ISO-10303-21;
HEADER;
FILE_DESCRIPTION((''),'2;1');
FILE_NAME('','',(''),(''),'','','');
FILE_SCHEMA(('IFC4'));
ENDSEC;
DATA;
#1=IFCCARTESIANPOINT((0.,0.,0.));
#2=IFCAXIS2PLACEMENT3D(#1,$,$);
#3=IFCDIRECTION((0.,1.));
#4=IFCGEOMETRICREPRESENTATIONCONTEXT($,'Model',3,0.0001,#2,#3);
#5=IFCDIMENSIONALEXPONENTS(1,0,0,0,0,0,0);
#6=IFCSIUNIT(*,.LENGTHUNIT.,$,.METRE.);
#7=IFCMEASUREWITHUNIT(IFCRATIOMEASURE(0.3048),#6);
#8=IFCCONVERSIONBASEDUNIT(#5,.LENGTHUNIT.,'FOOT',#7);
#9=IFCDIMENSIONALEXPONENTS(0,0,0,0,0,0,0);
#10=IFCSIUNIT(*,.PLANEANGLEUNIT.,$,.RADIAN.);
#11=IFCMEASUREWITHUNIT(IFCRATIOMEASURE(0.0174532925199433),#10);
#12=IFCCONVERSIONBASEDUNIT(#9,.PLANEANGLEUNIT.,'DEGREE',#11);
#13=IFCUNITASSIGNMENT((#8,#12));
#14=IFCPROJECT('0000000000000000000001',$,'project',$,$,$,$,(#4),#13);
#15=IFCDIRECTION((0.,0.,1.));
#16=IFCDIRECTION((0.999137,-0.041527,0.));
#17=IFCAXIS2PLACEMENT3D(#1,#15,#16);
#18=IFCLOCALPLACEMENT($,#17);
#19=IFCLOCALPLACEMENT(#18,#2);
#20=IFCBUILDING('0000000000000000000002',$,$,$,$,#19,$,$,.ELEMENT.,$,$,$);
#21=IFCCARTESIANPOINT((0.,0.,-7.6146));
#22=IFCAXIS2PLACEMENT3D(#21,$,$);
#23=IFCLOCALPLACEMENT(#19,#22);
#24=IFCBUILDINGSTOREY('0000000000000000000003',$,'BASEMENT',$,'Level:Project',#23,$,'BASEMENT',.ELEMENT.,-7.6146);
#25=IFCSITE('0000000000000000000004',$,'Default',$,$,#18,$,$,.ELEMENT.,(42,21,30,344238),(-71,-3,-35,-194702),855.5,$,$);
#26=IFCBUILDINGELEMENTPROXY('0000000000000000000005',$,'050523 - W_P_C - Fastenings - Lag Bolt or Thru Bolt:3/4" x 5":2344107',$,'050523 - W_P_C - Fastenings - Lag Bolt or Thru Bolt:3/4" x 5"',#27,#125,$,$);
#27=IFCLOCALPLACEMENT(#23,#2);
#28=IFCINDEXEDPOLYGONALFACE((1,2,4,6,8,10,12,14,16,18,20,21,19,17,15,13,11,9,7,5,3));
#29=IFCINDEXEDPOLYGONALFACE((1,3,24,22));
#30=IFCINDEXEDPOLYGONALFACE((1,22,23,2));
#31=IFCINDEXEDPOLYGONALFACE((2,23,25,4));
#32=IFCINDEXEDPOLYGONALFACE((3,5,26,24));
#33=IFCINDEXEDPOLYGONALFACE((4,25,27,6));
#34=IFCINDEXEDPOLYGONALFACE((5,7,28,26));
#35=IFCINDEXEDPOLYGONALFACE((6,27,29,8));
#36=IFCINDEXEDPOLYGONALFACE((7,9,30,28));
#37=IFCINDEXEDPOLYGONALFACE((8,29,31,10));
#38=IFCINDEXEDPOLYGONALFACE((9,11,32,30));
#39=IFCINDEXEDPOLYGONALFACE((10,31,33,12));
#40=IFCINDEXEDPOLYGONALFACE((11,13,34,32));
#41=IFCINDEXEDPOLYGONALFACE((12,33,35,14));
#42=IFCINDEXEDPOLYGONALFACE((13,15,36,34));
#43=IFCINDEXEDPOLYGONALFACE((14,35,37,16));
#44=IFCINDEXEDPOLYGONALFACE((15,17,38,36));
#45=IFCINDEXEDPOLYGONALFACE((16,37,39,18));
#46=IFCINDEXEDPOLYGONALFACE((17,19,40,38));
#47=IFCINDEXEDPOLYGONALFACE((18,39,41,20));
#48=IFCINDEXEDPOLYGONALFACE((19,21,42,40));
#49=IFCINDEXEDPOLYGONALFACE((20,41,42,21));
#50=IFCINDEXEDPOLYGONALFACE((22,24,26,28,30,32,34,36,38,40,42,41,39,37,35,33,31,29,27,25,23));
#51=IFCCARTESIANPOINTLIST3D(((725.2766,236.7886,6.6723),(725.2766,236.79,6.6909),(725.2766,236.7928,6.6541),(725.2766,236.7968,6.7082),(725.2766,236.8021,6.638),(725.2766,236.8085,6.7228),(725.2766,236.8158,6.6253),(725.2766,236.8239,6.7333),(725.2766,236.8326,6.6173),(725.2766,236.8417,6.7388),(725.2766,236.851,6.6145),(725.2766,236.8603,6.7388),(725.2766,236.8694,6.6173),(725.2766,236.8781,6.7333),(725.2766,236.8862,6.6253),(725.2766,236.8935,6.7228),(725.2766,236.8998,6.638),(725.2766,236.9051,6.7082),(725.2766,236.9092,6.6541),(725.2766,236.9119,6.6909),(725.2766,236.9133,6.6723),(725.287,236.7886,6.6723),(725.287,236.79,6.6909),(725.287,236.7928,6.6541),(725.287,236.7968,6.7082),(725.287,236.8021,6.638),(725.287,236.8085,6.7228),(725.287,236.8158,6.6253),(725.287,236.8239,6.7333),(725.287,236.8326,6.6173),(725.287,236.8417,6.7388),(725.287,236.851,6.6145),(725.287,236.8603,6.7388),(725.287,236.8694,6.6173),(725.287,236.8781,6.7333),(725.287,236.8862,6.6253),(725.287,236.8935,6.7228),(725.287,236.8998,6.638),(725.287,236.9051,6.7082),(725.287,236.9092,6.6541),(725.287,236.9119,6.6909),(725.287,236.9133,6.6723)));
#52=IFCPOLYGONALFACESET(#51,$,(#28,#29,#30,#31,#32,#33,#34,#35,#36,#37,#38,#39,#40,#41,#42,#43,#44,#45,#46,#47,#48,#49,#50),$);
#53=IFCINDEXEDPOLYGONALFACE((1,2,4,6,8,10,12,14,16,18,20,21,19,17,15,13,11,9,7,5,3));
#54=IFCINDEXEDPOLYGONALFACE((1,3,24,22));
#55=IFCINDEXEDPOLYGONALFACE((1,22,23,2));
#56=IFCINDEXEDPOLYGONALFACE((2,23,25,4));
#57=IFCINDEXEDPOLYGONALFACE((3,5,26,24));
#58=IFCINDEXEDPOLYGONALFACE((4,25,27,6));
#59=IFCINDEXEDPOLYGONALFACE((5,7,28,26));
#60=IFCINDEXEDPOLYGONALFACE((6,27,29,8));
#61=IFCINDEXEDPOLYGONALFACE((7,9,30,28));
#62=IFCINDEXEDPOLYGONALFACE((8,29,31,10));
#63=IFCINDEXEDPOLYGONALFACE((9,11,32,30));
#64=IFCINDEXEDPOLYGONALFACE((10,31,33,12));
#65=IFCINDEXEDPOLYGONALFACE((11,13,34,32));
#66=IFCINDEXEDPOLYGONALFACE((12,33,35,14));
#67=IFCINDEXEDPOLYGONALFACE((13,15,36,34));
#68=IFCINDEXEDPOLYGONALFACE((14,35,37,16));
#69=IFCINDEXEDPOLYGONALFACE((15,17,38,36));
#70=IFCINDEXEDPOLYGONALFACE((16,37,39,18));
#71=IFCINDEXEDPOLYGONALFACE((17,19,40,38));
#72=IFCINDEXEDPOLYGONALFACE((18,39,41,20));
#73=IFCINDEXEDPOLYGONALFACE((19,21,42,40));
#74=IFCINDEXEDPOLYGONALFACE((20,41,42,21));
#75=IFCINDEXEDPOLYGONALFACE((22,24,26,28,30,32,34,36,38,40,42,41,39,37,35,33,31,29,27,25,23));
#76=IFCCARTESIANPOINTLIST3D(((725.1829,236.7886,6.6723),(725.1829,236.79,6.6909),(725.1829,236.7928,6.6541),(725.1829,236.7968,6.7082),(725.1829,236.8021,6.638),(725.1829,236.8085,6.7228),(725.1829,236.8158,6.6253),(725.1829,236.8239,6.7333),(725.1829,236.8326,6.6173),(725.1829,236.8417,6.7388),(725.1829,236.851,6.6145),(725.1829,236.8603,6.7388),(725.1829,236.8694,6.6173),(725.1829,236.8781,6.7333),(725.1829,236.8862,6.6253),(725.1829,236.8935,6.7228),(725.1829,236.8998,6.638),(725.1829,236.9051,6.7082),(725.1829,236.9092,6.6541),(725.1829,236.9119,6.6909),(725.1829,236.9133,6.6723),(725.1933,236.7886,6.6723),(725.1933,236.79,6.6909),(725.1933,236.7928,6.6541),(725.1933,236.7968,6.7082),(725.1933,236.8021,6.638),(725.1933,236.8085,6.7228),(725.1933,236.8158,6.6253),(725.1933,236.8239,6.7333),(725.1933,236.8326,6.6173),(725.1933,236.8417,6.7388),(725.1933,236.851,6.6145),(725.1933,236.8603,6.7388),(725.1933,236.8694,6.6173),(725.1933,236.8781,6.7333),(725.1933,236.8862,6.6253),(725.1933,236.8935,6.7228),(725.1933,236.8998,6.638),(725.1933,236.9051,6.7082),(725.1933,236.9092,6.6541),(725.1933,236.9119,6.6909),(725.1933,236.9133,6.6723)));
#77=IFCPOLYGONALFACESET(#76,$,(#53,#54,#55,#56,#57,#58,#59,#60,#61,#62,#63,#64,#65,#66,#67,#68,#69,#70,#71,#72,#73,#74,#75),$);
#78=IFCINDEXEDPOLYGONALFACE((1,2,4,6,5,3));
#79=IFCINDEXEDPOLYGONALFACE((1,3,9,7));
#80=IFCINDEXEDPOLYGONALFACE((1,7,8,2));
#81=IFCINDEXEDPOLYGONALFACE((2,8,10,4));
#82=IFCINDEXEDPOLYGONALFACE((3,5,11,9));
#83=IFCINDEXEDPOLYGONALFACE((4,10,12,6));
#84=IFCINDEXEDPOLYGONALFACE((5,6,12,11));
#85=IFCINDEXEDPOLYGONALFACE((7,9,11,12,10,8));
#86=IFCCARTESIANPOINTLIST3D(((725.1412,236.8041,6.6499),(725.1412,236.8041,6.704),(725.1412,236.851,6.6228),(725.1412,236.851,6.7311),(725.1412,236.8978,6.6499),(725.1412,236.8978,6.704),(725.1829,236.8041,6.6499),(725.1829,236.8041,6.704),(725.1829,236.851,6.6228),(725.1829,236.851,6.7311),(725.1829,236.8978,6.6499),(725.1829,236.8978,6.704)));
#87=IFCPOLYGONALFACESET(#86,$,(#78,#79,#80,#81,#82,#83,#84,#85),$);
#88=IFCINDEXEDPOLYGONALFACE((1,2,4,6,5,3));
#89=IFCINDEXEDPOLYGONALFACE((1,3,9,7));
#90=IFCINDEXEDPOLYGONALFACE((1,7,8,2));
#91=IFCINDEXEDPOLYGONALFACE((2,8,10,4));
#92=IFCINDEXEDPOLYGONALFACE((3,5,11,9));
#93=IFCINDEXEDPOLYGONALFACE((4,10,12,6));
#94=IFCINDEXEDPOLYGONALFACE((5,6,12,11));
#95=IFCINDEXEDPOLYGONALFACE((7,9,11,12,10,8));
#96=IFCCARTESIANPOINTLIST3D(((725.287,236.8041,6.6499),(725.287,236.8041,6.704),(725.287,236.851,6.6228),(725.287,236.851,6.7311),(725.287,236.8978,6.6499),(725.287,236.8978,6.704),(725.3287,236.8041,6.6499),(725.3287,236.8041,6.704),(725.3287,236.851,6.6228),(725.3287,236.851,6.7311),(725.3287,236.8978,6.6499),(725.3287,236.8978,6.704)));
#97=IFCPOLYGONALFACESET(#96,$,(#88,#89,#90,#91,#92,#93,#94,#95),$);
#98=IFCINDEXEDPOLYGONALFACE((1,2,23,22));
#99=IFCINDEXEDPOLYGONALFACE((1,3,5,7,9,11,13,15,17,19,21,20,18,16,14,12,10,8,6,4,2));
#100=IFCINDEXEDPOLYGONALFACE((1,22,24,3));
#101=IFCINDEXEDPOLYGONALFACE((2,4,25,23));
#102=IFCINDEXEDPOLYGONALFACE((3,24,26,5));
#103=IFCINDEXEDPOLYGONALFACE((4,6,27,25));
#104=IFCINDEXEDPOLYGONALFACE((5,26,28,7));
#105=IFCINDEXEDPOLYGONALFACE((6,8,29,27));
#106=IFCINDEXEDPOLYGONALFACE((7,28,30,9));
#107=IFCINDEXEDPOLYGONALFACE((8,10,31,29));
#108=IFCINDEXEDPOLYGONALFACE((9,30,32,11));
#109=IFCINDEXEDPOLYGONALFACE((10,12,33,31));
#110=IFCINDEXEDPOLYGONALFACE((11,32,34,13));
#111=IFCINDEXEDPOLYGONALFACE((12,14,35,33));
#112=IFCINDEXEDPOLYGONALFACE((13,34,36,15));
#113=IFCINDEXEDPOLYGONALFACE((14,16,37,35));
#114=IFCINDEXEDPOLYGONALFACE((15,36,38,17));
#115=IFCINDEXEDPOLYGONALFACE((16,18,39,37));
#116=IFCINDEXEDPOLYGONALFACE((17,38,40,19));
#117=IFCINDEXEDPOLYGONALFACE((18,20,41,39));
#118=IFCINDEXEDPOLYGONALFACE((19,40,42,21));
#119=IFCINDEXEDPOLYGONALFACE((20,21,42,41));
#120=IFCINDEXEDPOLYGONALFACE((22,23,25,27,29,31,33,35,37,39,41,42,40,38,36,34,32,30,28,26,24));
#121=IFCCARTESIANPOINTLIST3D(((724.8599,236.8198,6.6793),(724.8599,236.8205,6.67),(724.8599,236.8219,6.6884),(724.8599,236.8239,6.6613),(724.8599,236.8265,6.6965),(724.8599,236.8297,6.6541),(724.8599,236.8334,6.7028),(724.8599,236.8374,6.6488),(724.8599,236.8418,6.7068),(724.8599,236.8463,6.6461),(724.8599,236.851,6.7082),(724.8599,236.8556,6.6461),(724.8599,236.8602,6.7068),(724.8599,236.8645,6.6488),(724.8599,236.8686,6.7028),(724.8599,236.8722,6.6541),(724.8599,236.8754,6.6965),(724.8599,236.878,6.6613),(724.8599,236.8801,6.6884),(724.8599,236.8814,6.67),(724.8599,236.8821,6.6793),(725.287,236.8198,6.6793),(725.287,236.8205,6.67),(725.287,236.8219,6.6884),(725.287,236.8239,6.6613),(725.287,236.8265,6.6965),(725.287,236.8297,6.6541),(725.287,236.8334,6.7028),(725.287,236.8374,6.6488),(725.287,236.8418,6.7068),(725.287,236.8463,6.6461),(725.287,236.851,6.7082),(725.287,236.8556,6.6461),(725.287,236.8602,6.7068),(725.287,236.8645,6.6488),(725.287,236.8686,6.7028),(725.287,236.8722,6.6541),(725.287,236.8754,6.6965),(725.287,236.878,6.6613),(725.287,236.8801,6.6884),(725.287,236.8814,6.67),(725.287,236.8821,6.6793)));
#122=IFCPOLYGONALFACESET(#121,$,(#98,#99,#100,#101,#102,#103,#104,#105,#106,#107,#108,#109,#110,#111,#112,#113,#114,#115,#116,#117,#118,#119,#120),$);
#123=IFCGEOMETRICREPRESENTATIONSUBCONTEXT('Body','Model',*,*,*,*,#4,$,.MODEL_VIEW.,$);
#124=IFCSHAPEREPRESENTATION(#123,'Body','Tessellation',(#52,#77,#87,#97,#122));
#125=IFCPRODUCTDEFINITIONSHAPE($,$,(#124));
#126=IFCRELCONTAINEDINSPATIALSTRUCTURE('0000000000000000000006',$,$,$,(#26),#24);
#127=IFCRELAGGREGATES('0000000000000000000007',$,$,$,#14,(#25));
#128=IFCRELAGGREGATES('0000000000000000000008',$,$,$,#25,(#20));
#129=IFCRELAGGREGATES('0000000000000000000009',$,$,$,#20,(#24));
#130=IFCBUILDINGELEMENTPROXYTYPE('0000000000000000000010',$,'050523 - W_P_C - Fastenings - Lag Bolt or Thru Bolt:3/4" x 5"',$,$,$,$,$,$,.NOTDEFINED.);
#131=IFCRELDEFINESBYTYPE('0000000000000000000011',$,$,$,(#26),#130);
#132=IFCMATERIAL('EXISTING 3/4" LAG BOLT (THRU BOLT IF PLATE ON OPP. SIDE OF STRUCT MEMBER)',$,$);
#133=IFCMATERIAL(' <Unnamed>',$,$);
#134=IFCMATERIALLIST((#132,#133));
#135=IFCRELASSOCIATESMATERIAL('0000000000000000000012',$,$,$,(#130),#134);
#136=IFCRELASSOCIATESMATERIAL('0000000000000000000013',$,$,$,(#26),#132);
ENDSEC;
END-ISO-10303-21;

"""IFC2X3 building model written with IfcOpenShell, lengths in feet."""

from ifc_helpers import new_model, entity, si_unit, converted_unit, direction, frame, frame_2d, origin, place, context, subcontext, project, spatial, polyline, circle, outline, extrude, source, transform, mapped, material, material_list, type_object, type_shapes, element, save


model = new_model("IFC2X3")

# Units and contexts
model_context = context("Model", 3, precision=0.0001, world=origin(), true_north=direction((0.0, 1.0)))
body_context = subcontext(model_context, "Body", "Model", "MODEL_VIEW")
ifc_project = project(units=[converted_unit("LENGTHUNIT", "FOOT", entity("IfcRatioMeasure", 0.3048), si_unit("LENGTHUNIT", "METRE"), dimensions=[1, 0, 0, 0, 0, 0, 0]), converted_unit("PLANEANGLEUNIT", "DEGREE", entity("IfcRatioMeasure", 0.0174532925199433), si_unit("PLANEANGLEUNIT", "RADIAN"), dimensions=[0, 0, 0, 0, 0, 0, 0])], contexts=[model_context])

# Site, building, storey
site_placement = place(None, frame((0.0, 0.0, 0.0), z_axis=(0.0, 0.0, 1.0), x_axis=(0.999137, -0.041527, 0.0)))
site = spatial("IfcSite", under=ifc_project, at=site_placement, Name="Default", CompositionType="ELEMENT", RefLatitude=(42, 21, 30, 344238), RefLongitude=(-71, -3, -35, -194702), RefElevation=855.5)
building_placement = place(site_placement, origin())
building = spatial("IfcBuilding", under=site, at=building_placement, CompositionType="ELEMENT")
storey_placement = place(building_placement, frame((0.0, 0.0, -7.6146)))
storey = spatial("IfcBuildingStorey", under=building, at=storey_placement, Name="BASEMENT", ObjectType="Level:Project", LongName="BASEMENT", CompositionType="ELEMENT", Elevation=-7.6146)

# Building element proxy
ifc_material_1 = material(Name=" <Unnamed>")
ifc_material_2 = material(Name="EXISTING 3/4\" LAG BOLT (THRU BOLT IF PLATE ON OPP. SIDE OF STRUCT MEMBER)")
ifc_material_list_1 = material_list([ifc_material_2, ifc_material_1])
building_element_proxy_type_1 = type_object("IfcBuildingElementProxyType", Name="050523 - W_P_C - Fastenings - Lag Bolt or Thru Bolt:3/4\" x 5\"", PredefinedType="NOTDEFINED", material=ifc_material_list_1)
shared_shape_1 = source(origin(), body_context, "Body", "SweptSolid", [
    extrude(circle(Radius=0.0625, at=frame_2d((0.0, 0.0), x_axis=(1.0, 0.0))), frame((0.0, 0.0, 0.0), z_axis=(0.0, 0.0, 1.0), x_axis=(0.0, 1.0, 0.0)), (0.0, 0.0, 1.0), 0.0104),
    extrude(circle(Radius=0.0625, at=frame_2d((0.0, 0.0), x_axis=(1.0, 0.0))), frame((0.0, 0.0, -0.0938), z_axis=(0.0, 0.0, 1.0), x_axis=(0.0, 1.0, 0.0)), (0.0, 0.0, 1.0), 0.0104),
    extrude(outline(polyline([(-0.0271, -0.0469), (0.0271, -0.0469), (0.0541, 0.0), (0.0271, 0.0469), (-0.0271, 0.0469), (-0.0541, 0.0), (-0.0271, -0.0469)])), frame((0.0, 0.0, -0.1354), z_axis=(0.0, 0.0, 1.0), x_axis=(0.0, -1.0, 0.0)), (0.0, 0.0, 1.0), 0.0417),
    extrude(outline(polyline([(-0.0271, -0.0469), (0.0271, -0.0469), (0.0541, 0.0), (0.0271, 0.0469), (-0.0271, 0.0469), (-0.0541, 0.0), (-0.0271, -0.0469)])), frame((0.0, 0.0, 0.0104), z_axis=(0.0, 0.0, 1.0), x_axis=(0.866025, -0.5, 0.0)), (0.0, 0.0, 1.0), 0.0417),
    extrude(circle(Radius=0.0312, at=frame_2d((0.0, 0.0), x_axis=(1.0, 0.0))), frame((0.0, 0.0, -0.4167), z_axis=(0.0, 0.0, 1.0), x_axis=(0.0, -1.0, 0.0)), (0.0, 0.0, 1.0), 0.4271),
])
type_shapes(building_element_proxy_type_1, [shared_shape_1])
for number, where, z_axis, x_axis, name in (
    (1, (725.2766, 236.851, 6.677), (1.0, 0.0, 0.0), (0.0, -1.0, 0.0), "050523 - W_P_C - Fastenings - Lag Bolt or Thru Bolt:3/4\" x 5\":2344107"),
):
    element("IfcBuildingElementProxy", number, at=place(storey_placement, frame(where, z_axis=z_axis, x_axis=x_axis)), inside=storey, type_object=building_element_proxy_type_1, material=ifc_material_2, Name=name, ObjectType="050523 - W_P_C - Fastenings - Lag Bolt or Thru Bolt:3/4\" x 5\"", context=body_context, shape_type="MappedRepresentation", body=[
        mapped(shared_shape_1, transform((0.0, 0.0, 0.0), scale=1.0)),
    ])

save(model, "model.ifc")
